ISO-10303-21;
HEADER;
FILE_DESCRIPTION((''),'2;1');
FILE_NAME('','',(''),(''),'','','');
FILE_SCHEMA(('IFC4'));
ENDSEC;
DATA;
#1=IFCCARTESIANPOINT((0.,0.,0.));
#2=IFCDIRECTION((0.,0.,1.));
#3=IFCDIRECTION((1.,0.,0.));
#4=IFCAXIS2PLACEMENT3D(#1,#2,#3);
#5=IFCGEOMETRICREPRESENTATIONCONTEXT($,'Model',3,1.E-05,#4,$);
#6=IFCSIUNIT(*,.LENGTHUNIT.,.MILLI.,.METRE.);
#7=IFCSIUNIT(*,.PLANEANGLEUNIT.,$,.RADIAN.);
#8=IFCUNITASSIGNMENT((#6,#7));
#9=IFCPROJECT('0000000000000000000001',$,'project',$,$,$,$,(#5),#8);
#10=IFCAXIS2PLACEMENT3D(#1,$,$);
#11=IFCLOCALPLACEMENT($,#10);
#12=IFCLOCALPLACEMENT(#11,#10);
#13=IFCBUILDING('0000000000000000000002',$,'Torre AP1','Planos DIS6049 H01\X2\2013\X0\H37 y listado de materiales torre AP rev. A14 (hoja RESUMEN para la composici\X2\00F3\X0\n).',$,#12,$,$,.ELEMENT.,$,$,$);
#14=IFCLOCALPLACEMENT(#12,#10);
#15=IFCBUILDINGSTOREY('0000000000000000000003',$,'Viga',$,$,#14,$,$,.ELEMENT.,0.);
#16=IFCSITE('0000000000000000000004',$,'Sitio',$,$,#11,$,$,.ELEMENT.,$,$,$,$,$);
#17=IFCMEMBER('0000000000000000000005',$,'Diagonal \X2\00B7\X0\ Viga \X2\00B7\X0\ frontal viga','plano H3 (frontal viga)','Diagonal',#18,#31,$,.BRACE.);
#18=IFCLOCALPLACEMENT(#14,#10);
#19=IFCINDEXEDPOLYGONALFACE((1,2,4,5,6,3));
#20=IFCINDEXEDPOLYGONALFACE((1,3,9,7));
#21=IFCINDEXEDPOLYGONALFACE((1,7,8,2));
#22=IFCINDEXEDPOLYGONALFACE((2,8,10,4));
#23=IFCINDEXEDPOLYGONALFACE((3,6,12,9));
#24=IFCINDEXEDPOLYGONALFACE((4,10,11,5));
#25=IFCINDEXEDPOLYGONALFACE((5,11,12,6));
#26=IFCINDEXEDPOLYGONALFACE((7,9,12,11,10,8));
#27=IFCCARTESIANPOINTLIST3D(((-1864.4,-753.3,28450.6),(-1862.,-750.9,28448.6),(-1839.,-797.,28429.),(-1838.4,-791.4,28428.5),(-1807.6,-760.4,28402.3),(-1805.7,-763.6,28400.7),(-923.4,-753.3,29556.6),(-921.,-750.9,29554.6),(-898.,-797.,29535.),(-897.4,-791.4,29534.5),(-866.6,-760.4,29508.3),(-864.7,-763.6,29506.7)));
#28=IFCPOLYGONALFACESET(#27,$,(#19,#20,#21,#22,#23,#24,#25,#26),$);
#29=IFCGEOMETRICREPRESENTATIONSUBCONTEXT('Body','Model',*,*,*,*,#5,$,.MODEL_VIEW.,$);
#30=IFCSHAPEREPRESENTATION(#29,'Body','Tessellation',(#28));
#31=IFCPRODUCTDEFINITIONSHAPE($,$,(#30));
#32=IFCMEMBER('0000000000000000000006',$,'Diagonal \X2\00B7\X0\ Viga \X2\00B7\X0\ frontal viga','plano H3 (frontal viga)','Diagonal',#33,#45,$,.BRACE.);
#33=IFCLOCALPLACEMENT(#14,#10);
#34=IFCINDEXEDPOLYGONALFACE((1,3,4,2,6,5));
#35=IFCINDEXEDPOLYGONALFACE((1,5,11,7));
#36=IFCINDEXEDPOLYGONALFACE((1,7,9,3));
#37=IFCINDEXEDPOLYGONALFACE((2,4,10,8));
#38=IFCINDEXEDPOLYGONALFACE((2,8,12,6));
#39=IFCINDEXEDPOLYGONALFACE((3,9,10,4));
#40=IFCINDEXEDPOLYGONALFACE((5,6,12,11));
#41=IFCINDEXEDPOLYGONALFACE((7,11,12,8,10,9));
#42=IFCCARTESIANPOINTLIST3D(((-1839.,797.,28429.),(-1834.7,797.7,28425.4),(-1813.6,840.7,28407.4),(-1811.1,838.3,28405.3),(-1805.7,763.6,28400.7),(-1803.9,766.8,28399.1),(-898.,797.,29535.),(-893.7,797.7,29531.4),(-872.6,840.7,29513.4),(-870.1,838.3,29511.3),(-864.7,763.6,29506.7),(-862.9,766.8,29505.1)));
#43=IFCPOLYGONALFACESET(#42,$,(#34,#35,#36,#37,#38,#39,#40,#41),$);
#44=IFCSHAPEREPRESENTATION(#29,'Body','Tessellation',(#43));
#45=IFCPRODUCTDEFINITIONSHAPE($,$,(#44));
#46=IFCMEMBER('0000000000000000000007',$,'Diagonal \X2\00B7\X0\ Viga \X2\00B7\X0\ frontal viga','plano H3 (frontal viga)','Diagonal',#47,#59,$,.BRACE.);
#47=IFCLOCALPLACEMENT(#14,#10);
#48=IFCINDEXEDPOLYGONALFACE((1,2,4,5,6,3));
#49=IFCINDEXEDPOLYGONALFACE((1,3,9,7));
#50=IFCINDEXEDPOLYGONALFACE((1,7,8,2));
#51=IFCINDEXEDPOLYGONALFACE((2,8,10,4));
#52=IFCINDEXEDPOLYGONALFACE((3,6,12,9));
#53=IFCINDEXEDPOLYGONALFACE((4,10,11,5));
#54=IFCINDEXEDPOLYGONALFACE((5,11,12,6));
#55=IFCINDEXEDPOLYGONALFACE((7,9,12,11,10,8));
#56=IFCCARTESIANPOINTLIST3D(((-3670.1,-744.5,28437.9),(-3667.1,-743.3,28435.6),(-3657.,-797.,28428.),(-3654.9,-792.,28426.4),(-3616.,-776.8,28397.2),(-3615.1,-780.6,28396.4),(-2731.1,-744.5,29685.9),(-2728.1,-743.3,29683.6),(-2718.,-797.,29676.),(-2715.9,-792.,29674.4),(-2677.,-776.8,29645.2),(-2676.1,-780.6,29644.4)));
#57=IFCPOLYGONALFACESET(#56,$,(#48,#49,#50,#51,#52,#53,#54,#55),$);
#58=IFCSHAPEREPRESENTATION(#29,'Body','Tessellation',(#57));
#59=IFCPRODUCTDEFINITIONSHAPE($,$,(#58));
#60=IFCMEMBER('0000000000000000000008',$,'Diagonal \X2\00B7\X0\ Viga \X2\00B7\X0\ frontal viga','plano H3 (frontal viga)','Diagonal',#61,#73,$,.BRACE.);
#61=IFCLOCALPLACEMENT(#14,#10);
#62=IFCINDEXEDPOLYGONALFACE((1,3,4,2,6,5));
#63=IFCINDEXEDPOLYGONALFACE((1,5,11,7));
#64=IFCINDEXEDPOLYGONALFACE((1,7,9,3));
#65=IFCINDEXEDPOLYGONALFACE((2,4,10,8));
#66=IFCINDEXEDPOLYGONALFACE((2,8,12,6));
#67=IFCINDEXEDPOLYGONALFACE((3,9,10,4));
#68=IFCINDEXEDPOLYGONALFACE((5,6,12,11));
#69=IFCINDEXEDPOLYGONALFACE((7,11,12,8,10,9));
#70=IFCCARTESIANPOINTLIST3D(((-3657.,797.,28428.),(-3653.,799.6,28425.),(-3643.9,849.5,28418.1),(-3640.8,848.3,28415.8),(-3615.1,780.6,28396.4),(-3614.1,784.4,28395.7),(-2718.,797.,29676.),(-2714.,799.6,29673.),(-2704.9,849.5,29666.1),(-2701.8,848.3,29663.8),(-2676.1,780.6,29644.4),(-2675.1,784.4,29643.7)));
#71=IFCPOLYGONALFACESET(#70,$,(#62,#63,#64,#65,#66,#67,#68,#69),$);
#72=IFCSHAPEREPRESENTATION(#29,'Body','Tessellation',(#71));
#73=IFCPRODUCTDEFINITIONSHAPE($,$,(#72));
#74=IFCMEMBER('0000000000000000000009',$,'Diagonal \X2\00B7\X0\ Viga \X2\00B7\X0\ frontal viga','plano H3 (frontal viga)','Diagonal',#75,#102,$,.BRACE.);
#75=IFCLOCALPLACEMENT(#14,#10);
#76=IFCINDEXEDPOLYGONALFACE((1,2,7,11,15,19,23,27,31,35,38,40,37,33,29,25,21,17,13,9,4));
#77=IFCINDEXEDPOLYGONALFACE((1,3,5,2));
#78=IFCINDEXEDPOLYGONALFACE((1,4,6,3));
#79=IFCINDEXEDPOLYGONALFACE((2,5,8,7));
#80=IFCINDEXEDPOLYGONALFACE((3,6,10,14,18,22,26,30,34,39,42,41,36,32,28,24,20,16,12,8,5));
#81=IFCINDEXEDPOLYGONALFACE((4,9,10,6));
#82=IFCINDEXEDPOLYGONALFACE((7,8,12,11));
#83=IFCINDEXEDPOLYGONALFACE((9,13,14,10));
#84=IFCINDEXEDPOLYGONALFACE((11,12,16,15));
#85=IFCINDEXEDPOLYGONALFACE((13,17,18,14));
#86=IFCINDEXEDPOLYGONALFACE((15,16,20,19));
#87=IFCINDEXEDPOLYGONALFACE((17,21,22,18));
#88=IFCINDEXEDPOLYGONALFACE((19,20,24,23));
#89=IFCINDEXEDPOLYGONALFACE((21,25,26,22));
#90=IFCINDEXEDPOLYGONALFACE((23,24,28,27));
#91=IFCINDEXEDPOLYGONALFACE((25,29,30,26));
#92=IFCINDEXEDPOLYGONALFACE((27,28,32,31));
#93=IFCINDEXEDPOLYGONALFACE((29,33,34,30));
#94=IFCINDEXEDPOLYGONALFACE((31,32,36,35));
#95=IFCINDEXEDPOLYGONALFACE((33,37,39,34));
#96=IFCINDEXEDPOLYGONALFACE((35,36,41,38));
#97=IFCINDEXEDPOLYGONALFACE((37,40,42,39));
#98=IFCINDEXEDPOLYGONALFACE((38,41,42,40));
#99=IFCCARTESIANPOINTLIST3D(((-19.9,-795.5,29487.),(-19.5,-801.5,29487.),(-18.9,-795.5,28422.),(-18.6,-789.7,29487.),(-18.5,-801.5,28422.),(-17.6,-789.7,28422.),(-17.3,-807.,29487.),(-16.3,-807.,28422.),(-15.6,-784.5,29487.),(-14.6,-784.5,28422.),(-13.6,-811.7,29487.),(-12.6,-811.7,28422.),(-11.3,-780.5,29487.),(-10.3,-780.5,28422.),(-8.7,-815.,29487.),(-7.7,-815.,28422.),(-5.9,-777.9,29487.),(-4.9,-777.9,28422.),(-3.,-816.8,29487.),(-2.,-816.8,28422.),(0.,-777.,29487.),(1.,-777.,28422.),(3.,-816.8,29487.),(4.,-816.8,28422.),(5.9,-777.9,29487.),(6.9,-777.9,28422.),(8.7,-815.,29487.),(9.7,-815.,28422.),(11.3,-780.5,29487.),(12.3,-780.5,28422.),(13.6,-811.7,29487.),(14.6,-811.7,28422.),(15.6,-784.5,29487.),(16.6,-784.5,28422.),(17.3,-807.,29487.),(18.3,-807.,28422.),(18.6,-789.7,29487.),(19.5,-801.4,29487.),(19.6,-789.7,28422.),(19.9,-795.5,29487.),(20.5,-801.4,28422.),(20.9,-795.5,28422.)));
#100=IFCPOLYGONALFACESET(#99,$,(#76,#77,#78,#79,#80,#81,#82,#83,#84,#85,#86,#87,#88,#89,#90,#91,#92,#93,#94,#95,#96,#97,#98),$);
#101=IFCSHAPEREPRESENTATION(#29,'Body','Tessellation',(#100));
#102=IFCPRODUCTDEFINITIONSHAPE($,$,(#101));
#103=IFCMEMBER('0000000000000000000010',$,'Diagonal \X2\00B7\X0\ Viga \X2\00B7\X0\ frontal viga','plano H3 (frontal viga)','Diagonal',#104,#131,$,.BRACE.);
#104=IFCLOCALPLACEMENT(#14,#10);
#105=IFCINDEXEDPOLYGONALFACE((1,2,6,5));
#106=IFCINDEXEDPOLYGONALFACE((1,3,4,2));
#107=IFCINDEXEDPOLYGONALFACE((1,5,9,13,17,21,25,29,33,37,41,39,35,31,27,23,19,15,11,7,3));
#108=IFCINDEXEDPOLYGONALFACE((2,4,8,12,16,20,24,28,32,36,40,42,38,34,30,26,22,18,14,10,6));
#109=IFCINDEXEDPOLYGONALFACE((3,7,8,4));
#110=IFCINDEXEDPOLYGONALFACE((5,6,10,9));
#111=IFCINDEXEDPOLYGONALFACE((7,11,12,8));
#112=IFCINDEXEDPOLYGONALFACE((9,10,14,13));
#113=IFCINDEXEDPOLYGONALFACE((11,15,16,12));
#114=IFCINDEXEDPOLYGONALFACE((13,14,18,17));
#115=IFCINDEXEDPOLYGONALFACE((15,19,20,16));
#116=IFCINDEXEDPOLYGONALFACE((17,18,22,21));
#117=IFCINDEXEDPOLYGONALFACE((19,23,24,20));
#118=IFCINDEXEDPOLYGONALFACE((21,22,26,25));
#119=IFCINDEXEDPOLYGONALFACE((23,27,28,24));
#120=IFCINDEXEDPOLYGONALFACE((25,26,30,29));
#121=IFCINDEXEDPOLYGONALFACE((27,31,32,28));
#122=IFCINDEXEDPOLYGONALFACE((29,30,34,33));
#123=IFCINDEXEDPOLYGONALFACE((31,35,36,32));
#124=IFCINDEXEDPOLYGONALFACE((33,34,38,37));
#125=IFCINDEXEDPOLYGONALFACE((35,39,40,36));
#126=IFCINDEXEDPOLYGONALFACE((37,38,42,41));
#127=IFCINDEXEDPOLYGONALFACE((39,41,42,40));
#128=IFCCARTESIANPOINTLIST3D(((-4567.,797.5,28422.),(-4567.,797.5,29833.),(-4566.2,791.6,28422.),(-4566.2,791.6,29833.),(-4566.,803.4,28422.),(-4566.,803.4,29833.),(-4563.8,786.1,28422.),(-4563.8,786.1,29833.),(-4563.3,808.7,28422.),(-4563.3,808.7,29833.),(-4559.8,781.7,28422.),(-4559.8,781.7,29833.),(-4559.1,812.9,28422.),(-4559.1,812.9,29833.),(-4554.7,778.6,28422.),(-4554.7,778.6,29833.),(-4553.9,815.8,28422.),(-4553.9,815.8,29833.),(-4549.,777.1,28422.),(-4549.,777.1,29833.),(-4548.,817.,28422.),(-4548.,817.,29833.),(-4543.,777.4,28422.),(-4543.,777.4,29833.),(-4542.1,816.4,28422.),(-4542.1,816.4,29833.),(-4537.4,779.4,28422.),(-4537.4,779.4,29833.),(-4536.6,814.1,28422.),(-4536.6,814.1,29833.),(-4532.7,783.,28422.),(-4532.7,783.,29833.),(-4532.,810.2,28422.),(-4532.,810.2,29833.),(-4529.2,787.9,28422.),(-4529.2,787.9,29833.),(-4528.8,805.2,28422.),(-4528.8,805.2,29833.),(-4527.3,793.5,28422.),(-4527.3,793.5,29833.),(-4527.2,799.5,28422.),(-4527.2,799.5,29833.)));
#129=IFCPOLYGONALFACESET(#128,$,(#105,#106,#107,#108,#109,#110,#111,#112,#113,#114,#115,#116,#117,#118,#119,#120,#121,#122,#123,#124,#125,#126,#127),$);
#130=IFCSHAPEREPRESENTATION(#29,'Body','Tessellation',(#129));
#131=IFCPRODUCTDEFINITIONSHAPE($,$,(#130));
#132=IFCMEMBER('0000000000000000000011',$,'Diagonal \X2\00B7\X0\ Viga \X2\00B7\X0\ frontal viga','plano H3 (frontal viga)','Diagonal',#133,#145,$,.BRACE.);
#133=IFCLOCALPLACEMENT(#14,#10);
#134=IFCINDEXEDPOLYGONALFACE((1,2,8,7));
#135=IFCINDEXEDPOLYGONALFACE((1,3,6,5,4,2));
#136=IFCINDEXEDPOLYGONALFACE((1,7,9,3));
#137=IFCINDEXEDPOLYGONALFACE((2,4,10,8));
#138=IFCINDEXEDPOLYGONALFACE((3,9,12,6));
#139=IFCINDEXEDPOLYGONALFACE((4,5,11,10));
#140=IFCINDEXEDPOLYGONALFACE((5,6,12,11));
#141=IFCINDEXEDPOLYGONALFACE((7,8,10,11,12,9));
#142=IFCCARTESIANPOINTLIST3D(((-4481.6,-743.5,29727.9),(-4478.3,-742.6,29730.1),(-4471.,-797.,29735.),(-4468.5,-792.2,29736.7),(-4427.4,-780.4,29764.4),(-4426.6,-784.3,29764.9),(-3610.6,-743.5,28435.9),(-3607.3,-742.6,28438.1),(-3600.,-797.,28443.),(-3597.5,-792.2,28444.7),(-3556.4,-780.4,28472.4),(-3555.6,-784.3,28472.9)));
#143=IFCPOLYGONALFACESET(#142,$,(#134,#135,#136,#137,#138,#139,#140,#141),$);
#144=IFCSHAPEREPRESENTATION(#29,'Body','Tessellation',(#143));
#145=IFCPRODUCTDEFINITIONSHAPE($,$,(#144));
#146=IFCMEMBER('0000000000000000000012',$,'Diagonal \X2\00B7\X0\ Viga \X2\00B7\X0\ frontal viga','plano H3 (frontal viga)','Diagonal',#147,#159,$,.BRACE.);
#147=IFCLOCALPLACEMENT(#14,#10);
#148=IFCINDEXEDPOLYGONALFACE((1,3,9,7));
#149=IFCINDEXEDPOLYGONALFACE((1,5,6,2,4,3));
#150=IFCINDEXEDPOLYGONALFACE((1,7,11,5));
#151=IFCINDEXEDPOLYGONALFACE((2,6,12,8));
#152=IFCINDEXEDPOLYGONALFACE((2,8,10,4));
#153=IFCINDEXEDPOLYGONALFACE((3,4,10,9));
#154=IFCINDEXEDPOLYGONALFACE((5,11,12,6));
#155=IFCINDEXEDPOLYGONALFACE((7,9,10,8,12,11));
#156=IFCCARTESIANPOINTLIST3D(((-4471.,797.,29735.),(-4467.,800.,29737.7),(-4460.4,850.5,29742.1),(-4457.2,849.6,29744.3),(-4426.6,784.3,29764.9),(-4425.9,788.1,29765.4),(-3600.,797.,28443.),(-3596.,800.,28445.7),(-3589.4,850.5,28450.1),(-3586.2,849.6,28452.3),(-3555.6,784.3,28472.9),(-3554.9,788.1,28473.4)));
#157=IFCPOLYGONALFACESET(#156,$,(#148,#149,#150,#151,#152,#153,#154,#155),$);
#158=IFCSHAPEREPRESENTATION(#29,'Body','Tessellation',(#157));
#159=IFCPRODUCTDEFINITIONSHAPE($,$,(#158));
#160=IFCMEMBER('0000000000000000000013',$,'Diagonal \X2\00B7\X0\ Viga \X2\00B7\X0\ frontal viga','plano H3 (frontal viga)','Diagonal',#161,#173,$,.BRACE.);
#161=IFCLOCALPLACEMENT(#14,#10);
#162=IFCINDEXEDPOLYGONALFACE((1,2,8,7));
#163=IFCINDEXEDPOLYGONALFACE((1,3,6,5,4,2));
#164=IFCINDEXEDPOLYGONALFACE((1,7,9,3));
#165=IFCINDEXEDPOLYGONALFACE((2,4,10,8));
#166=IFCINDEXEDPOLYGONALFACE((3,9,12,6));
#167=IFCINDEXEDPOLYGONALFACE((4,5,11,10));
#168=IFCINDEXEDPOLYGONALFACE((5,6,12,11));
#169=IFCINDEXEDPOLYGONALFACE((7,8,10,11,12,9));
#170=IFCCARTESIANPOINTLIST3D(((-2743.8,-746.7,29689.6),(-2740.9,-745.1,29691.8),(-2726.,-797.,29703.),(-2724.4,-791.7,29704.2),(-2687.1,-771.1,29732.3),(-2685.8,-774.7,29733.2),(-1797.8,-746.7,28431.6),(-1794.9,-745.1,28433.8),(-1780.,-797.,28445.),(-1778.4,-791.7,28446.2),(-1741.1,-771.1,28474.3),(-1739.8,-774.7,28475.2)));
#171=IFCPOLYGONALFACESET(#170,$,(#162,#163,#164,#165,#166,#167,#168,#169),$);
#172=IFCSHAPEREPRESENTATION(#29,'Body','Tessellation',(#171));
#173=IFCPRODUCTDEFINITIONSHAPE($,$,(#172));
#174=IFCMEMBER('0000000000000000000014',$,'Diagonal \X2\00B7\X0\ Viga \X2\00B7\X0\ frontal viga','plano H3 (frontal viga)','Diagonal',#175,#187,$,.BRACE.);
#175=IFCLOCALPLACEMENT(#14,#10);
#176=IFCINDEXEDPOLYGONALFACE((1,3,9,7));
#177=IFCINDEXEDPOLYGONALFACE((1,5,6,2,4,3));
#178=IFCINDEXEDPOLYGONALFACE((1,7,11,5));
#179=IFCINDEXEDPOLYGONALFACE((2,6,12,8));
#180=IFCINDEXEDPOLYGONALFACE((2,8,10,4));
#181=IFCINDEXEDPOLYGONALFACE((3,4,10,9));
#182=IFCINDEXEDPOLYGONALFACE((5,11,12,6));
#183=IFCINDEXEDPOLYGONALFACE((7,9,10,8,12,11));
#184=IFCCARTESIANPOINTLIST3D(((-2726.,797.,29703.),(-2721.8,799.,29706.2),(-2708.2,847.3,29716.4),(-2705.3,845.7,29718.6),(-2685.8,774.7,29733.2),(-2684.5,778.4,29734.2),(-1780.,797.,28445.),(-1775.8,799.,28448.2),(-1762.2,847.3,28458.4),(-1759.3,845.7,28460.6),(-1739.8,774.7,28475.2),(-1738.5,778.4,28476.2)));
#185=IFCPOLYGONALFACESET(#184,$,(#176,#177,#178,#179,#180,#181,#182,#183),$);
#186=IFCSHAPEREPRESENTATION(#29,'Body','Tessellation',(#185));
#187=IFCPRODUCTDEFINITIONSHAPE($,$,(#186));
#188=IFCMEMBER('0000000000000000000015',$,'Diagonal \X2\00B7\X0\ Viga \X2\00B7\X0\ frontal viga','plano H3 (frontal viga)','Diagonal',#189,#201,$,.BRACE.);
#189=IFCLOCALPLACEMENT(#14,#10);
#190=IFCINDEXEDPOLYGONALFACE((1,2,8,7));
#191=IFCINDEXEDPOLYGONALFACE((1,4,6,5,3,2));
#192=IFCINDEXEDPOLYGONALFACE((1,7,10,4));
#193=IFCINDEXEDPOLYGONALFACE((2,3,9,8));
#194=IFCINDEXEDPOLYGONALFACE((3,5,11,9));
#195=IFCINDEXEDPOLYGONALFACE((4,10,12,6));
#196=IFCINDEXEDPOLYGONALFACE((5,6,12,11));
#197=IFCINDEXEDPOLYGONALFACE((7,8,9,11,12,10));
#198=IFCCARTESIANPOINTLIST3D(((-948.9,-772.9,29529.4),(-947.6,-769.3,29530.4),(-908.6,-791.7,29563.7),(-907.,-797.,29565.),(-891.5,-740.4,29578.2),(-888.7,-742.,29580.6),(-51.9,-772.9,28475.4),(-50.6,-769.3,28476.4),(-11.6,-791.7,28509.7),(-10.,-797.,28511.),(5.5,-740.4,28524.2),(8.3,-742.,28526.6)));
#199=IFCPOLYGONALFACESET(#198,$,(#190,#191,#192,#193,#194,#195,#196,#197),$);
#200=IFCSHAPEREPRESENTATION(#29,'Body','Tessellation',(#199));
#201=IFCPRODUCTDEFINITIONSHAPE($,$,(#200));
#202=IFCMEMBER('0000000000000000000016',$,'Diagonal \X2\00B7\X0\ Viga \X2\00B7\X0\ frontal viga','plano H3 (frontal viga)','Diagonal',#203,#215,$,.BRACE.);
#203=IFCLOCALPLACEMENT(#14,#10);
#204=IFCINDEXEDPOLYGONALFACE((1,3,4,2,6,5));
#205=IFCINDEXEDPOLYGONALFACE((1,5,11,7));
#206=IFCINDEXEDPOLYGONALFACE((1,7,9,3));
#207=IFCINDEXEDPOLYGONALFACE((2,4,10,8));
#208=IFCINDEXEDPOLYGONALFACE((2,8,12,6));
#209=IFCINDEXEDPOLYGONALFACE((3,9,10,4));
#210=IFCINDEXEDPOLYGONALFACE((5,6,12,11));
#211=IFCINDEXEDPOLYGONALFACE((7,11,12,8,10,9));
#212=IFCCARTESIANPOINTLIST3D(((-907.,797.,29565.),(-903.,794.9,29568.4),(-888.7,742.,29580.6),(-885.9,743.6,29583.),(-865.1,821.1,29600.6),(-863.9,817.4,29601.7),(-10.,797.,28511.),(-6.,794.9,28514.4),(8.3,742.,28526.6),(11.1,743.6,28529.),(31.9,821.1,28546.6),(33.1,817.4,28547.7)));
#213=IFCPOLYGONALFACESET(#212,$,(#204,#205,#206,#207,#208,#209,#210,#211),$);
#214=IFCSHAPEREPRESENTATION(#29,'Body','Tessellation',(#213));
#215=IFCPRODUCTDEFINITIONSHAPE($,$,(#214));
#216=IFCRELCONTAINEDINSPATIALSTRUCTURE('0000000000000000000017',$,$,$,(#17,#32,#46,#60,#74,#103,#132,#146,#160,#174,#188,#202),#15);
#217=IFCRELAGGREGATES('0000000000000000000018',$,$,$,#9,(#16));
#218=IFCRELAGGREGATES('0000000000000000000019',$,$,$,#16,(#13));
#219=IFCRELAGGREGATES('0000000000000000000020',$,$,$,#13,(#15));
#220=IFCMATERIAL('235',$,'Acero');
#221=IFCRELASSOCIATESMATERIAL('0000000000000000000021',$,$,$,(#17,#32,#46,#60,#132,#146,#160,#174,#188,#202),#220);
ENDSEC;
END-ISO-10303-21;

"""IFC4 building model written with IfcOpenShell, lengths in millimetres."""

from ifc_helpers import new_model, si_unit, frame, frame_2d, origin, origin_with_axes, place, context, subcontext, project, spatial, circle, l_section, extrude, material, element, save


model = new_model("IFC4")

# Units and contexts
model_context = context("Model", 3, precision=1e-05, world=origin_with_axes())
body_context = subcontext(model_context, "Body", "Model", "MODEL_VIEW")
ifc_project = project(units=[si_unit("LENGTHUNIT", "METRE", prefix="MILLI"), si_unit("PLANEANGLEUNIT", "RADIAN")], contexts=[model_context])

# Site, building, storey
site_placement = place(None, origin())
site = spatial("IfcSite", under=ifc_project, at=site_placement, Name="Sitio", CompositionType="ELEMENT")
building_placement = place(site_placement, origin())
building = spatial("IfcBuilding", under=site, at=building_placement, Name="Torre AP1", Description="Planos DIS6049 H01–H37 y listado de materiales torre AP rev. A14 (hoja RESUMEN para la composición).", CompositionType="ELEMENT")
storey_placement = place(building_placement, origin())
storey = spatial("IfcBuildingStorey", under=building, at=storey_placement, Name="Viga", CompositionType="ELEMENT", Elevation=0.0)

# Members
ifc_material = material(Name="235", Category="Acero")
for number, where, z_axis, x_axis, name in (
    (1, (-1839.0, -797.0, 28429.0), (0.648008, 0.0, 0.761633), (0.605023, 0.607426, -0.514762), "Diagonal · Viga · frontal viga"),
    (2, (-1839.0, 797.0, 28429.0), (0.648008, 0.0, 0.761633), (0.605023, -0.607426, -0.514762), "Diagonal · Viga · frontal viga"),
):
    element("IfcMember", number, at=place(storey_placement, frame(where, z_axis=z_axis, x_axis=x_axis)), inside=storey, material=ifc_material, Name=name, Description="plano H3 (frontal viga)", ObjectType="Diagonal", PredefinedType="BRACE", context=body_context, shape_type="SweptSolid", body=[
        extrude(l_section(Depth=55.0, Width=55.0, Thickness=4.0, at=frame_2d((27.5, 27.5))), None, (0.0, 0.0, 1.0), 1452.1),
    ])
for number, where, z_axis, x_axis, name in (
    (3, (-3657.0, -797.0, 28428.0), (0.601229, 0.0, 0.799077), (0.762614, 0.298631, -0.573794), "Diagonal · Viga · frontal viga"),
    (4, (-3657.0, 797.0, 28428.0), (0.601229, 0.0, 0.799077), (0.762614, -0.298631, -0.573794), "Diagonal · Viga · frontal viga"),
):
    element("IfcMember", number, at=place(storey_placement, frame(where, z_axis=z_axis, x_axis=x_axis)), inside=storey, material=ifc_material, Name=name, Description="plano H3 (frontal viga)", ObjectType="Diagonal", PredefinedType="BRACE", context=body_context, shape_type="SweptSolid", body=[
        extrude(l_section(Depth=55.0, Width=55.0, Thickness=4.0, at=frame_2d((27.5, 27.5))), None, (0.0, 0.0, 1.0), 1561.8),
    ])
member_1_placement = place(storey_placement, frame((1.0, -797.0, 28422.0), z_axis=(-0.000939, 0.0, 1.0), x_axis=(-0.000627, 1.0, -0.000001)))
element("IfcMember", 5, at=member_1_placement, inside=storey, Name="Diagonal · Viga · frontal viga", Description="plano H3 (frontal viga)", ObjectType="Diagonal", PredefinedType="BRACE", context=body_context, shape_type="SweptSolid", body=[
    extrude(circle(Radius=20.0), None, (0.0, 0.0, 1.0), 1065.0),
])
member_2_placement = place(storey_placement, frame((-4547.0, 797.0, 28422.0), z_axis=(0.0, 0.0, 1.0), x_axis=(0.984984, -0.172648, 0.0)))
element("IfcMember", 6, at=member_2_placement, inside=storey, Name="Diagonal · Viga · frontal viga", Description="plano H3 (frontal viga)", ObjectType="Diagonal", PredefinedType="BRACE", context=body_context, shape_type="SweptSolid", body=[
    extrude(circle(Radius=20.0), None, (0.0, 0.0, 1.0), 1411.0),
])
for number, where, z_axis, x_axis, name in (
    (7, (-3600.0, -797.0, 28443.0), (-0.558988, 0.0, 0.829176), (0.806611, 0.231703, 0.543776), "Diagonal · Viga · frontal viga"),
    (8, (-3600.0, 797.0, 28443.0), (-0.558988, 0.0, 0.829176), (0.806611, -0.231703, 0.543776), "Diagonal · Viga · frontal viga"),
):
    element("IfcMember", number, at=place(storey_placement, frame(where, z_axis=z_axis, x_axis=x_axis)), inside=storey, material=ifc_material, Name=name, Description="plano H3 (frontal viga)", ObjectType="Diagonal", PredefinedType="BRACE", context=body_context, shape_type="SweptSolid", body=[
        extrude(l_section(Depth=55.0, Width=55.0, Thickness=4.0, at=frame_2d((27.5, 27.5))), None, (0.0, 0.0, 1.0), 1558.2),
    ])
for number, where, z_axis, x_axis, name in (
    (9, (-1780.0, -797.0, 28445.0), (-0.601016, 0.0, 0.799237), (0.730849, 0.404737, 0.549589), "Diagonal · Viga · frontal viga"),
    (10, (-1780.0, 797.0, 28445.0), (-0.601016, 0.0, 0.799237), (0.730849, -0.404737, 0.549589), "Diagonal · Viga · frontal viga"),
):
    element("IfcMember", number, at=place(storey_placement, frame(where, z_axis=z_axis, x_axis=x_axis)), inside=storey, material=ifc_material, Name=name, Description="plano H3 (frontal viga)", ObjectType="Diagonal", PredefinedType="BRACE", context=body_context, shape_type="SweptSolid", body=[
        extrude(l_section(Depth=55.0, Width=55.0, Thickness=4.0, at=frame_2d((27.5, 27.5))), None, (0.0, 0.0, 1.0), 1574.0),
    ])
for number, where, z_axis, x_axis, name in (
    (11, (-10.0, -797.0, 28511.0), (-0.64811, 0.0, 0.761547), (0.305596, 0.915954, 0.260076), "Diagonal · Viga · frontal viga"),
    (12, (-10.0, 797.0, 28511.0), (-0.64811, 0.0, 0.761547), (0.305596, -0.915954, 0.260076), "Diagonal · Viga · frontal viga"),
):
    element("IfcMember", number, at=place(storey_placement, frame(where, z_axis=z_axis, x_axis=x_axis)), inside=storey, material=ifc_material, Name=name, Description="plano H3 (frontal viga)", ObjectType="Diagonal", PredefinedType="BRACE", context=body_context, shape_type="SweptSolid", body=[
        extrude(l_section(Depth=60.0, Width=60.0, Thickness=4.0, at=frame_2d((30.0, 30.0))), None, (0.0, 0.0, 1.0), 1384.0),
    ])

save(model, "model.ifc")
